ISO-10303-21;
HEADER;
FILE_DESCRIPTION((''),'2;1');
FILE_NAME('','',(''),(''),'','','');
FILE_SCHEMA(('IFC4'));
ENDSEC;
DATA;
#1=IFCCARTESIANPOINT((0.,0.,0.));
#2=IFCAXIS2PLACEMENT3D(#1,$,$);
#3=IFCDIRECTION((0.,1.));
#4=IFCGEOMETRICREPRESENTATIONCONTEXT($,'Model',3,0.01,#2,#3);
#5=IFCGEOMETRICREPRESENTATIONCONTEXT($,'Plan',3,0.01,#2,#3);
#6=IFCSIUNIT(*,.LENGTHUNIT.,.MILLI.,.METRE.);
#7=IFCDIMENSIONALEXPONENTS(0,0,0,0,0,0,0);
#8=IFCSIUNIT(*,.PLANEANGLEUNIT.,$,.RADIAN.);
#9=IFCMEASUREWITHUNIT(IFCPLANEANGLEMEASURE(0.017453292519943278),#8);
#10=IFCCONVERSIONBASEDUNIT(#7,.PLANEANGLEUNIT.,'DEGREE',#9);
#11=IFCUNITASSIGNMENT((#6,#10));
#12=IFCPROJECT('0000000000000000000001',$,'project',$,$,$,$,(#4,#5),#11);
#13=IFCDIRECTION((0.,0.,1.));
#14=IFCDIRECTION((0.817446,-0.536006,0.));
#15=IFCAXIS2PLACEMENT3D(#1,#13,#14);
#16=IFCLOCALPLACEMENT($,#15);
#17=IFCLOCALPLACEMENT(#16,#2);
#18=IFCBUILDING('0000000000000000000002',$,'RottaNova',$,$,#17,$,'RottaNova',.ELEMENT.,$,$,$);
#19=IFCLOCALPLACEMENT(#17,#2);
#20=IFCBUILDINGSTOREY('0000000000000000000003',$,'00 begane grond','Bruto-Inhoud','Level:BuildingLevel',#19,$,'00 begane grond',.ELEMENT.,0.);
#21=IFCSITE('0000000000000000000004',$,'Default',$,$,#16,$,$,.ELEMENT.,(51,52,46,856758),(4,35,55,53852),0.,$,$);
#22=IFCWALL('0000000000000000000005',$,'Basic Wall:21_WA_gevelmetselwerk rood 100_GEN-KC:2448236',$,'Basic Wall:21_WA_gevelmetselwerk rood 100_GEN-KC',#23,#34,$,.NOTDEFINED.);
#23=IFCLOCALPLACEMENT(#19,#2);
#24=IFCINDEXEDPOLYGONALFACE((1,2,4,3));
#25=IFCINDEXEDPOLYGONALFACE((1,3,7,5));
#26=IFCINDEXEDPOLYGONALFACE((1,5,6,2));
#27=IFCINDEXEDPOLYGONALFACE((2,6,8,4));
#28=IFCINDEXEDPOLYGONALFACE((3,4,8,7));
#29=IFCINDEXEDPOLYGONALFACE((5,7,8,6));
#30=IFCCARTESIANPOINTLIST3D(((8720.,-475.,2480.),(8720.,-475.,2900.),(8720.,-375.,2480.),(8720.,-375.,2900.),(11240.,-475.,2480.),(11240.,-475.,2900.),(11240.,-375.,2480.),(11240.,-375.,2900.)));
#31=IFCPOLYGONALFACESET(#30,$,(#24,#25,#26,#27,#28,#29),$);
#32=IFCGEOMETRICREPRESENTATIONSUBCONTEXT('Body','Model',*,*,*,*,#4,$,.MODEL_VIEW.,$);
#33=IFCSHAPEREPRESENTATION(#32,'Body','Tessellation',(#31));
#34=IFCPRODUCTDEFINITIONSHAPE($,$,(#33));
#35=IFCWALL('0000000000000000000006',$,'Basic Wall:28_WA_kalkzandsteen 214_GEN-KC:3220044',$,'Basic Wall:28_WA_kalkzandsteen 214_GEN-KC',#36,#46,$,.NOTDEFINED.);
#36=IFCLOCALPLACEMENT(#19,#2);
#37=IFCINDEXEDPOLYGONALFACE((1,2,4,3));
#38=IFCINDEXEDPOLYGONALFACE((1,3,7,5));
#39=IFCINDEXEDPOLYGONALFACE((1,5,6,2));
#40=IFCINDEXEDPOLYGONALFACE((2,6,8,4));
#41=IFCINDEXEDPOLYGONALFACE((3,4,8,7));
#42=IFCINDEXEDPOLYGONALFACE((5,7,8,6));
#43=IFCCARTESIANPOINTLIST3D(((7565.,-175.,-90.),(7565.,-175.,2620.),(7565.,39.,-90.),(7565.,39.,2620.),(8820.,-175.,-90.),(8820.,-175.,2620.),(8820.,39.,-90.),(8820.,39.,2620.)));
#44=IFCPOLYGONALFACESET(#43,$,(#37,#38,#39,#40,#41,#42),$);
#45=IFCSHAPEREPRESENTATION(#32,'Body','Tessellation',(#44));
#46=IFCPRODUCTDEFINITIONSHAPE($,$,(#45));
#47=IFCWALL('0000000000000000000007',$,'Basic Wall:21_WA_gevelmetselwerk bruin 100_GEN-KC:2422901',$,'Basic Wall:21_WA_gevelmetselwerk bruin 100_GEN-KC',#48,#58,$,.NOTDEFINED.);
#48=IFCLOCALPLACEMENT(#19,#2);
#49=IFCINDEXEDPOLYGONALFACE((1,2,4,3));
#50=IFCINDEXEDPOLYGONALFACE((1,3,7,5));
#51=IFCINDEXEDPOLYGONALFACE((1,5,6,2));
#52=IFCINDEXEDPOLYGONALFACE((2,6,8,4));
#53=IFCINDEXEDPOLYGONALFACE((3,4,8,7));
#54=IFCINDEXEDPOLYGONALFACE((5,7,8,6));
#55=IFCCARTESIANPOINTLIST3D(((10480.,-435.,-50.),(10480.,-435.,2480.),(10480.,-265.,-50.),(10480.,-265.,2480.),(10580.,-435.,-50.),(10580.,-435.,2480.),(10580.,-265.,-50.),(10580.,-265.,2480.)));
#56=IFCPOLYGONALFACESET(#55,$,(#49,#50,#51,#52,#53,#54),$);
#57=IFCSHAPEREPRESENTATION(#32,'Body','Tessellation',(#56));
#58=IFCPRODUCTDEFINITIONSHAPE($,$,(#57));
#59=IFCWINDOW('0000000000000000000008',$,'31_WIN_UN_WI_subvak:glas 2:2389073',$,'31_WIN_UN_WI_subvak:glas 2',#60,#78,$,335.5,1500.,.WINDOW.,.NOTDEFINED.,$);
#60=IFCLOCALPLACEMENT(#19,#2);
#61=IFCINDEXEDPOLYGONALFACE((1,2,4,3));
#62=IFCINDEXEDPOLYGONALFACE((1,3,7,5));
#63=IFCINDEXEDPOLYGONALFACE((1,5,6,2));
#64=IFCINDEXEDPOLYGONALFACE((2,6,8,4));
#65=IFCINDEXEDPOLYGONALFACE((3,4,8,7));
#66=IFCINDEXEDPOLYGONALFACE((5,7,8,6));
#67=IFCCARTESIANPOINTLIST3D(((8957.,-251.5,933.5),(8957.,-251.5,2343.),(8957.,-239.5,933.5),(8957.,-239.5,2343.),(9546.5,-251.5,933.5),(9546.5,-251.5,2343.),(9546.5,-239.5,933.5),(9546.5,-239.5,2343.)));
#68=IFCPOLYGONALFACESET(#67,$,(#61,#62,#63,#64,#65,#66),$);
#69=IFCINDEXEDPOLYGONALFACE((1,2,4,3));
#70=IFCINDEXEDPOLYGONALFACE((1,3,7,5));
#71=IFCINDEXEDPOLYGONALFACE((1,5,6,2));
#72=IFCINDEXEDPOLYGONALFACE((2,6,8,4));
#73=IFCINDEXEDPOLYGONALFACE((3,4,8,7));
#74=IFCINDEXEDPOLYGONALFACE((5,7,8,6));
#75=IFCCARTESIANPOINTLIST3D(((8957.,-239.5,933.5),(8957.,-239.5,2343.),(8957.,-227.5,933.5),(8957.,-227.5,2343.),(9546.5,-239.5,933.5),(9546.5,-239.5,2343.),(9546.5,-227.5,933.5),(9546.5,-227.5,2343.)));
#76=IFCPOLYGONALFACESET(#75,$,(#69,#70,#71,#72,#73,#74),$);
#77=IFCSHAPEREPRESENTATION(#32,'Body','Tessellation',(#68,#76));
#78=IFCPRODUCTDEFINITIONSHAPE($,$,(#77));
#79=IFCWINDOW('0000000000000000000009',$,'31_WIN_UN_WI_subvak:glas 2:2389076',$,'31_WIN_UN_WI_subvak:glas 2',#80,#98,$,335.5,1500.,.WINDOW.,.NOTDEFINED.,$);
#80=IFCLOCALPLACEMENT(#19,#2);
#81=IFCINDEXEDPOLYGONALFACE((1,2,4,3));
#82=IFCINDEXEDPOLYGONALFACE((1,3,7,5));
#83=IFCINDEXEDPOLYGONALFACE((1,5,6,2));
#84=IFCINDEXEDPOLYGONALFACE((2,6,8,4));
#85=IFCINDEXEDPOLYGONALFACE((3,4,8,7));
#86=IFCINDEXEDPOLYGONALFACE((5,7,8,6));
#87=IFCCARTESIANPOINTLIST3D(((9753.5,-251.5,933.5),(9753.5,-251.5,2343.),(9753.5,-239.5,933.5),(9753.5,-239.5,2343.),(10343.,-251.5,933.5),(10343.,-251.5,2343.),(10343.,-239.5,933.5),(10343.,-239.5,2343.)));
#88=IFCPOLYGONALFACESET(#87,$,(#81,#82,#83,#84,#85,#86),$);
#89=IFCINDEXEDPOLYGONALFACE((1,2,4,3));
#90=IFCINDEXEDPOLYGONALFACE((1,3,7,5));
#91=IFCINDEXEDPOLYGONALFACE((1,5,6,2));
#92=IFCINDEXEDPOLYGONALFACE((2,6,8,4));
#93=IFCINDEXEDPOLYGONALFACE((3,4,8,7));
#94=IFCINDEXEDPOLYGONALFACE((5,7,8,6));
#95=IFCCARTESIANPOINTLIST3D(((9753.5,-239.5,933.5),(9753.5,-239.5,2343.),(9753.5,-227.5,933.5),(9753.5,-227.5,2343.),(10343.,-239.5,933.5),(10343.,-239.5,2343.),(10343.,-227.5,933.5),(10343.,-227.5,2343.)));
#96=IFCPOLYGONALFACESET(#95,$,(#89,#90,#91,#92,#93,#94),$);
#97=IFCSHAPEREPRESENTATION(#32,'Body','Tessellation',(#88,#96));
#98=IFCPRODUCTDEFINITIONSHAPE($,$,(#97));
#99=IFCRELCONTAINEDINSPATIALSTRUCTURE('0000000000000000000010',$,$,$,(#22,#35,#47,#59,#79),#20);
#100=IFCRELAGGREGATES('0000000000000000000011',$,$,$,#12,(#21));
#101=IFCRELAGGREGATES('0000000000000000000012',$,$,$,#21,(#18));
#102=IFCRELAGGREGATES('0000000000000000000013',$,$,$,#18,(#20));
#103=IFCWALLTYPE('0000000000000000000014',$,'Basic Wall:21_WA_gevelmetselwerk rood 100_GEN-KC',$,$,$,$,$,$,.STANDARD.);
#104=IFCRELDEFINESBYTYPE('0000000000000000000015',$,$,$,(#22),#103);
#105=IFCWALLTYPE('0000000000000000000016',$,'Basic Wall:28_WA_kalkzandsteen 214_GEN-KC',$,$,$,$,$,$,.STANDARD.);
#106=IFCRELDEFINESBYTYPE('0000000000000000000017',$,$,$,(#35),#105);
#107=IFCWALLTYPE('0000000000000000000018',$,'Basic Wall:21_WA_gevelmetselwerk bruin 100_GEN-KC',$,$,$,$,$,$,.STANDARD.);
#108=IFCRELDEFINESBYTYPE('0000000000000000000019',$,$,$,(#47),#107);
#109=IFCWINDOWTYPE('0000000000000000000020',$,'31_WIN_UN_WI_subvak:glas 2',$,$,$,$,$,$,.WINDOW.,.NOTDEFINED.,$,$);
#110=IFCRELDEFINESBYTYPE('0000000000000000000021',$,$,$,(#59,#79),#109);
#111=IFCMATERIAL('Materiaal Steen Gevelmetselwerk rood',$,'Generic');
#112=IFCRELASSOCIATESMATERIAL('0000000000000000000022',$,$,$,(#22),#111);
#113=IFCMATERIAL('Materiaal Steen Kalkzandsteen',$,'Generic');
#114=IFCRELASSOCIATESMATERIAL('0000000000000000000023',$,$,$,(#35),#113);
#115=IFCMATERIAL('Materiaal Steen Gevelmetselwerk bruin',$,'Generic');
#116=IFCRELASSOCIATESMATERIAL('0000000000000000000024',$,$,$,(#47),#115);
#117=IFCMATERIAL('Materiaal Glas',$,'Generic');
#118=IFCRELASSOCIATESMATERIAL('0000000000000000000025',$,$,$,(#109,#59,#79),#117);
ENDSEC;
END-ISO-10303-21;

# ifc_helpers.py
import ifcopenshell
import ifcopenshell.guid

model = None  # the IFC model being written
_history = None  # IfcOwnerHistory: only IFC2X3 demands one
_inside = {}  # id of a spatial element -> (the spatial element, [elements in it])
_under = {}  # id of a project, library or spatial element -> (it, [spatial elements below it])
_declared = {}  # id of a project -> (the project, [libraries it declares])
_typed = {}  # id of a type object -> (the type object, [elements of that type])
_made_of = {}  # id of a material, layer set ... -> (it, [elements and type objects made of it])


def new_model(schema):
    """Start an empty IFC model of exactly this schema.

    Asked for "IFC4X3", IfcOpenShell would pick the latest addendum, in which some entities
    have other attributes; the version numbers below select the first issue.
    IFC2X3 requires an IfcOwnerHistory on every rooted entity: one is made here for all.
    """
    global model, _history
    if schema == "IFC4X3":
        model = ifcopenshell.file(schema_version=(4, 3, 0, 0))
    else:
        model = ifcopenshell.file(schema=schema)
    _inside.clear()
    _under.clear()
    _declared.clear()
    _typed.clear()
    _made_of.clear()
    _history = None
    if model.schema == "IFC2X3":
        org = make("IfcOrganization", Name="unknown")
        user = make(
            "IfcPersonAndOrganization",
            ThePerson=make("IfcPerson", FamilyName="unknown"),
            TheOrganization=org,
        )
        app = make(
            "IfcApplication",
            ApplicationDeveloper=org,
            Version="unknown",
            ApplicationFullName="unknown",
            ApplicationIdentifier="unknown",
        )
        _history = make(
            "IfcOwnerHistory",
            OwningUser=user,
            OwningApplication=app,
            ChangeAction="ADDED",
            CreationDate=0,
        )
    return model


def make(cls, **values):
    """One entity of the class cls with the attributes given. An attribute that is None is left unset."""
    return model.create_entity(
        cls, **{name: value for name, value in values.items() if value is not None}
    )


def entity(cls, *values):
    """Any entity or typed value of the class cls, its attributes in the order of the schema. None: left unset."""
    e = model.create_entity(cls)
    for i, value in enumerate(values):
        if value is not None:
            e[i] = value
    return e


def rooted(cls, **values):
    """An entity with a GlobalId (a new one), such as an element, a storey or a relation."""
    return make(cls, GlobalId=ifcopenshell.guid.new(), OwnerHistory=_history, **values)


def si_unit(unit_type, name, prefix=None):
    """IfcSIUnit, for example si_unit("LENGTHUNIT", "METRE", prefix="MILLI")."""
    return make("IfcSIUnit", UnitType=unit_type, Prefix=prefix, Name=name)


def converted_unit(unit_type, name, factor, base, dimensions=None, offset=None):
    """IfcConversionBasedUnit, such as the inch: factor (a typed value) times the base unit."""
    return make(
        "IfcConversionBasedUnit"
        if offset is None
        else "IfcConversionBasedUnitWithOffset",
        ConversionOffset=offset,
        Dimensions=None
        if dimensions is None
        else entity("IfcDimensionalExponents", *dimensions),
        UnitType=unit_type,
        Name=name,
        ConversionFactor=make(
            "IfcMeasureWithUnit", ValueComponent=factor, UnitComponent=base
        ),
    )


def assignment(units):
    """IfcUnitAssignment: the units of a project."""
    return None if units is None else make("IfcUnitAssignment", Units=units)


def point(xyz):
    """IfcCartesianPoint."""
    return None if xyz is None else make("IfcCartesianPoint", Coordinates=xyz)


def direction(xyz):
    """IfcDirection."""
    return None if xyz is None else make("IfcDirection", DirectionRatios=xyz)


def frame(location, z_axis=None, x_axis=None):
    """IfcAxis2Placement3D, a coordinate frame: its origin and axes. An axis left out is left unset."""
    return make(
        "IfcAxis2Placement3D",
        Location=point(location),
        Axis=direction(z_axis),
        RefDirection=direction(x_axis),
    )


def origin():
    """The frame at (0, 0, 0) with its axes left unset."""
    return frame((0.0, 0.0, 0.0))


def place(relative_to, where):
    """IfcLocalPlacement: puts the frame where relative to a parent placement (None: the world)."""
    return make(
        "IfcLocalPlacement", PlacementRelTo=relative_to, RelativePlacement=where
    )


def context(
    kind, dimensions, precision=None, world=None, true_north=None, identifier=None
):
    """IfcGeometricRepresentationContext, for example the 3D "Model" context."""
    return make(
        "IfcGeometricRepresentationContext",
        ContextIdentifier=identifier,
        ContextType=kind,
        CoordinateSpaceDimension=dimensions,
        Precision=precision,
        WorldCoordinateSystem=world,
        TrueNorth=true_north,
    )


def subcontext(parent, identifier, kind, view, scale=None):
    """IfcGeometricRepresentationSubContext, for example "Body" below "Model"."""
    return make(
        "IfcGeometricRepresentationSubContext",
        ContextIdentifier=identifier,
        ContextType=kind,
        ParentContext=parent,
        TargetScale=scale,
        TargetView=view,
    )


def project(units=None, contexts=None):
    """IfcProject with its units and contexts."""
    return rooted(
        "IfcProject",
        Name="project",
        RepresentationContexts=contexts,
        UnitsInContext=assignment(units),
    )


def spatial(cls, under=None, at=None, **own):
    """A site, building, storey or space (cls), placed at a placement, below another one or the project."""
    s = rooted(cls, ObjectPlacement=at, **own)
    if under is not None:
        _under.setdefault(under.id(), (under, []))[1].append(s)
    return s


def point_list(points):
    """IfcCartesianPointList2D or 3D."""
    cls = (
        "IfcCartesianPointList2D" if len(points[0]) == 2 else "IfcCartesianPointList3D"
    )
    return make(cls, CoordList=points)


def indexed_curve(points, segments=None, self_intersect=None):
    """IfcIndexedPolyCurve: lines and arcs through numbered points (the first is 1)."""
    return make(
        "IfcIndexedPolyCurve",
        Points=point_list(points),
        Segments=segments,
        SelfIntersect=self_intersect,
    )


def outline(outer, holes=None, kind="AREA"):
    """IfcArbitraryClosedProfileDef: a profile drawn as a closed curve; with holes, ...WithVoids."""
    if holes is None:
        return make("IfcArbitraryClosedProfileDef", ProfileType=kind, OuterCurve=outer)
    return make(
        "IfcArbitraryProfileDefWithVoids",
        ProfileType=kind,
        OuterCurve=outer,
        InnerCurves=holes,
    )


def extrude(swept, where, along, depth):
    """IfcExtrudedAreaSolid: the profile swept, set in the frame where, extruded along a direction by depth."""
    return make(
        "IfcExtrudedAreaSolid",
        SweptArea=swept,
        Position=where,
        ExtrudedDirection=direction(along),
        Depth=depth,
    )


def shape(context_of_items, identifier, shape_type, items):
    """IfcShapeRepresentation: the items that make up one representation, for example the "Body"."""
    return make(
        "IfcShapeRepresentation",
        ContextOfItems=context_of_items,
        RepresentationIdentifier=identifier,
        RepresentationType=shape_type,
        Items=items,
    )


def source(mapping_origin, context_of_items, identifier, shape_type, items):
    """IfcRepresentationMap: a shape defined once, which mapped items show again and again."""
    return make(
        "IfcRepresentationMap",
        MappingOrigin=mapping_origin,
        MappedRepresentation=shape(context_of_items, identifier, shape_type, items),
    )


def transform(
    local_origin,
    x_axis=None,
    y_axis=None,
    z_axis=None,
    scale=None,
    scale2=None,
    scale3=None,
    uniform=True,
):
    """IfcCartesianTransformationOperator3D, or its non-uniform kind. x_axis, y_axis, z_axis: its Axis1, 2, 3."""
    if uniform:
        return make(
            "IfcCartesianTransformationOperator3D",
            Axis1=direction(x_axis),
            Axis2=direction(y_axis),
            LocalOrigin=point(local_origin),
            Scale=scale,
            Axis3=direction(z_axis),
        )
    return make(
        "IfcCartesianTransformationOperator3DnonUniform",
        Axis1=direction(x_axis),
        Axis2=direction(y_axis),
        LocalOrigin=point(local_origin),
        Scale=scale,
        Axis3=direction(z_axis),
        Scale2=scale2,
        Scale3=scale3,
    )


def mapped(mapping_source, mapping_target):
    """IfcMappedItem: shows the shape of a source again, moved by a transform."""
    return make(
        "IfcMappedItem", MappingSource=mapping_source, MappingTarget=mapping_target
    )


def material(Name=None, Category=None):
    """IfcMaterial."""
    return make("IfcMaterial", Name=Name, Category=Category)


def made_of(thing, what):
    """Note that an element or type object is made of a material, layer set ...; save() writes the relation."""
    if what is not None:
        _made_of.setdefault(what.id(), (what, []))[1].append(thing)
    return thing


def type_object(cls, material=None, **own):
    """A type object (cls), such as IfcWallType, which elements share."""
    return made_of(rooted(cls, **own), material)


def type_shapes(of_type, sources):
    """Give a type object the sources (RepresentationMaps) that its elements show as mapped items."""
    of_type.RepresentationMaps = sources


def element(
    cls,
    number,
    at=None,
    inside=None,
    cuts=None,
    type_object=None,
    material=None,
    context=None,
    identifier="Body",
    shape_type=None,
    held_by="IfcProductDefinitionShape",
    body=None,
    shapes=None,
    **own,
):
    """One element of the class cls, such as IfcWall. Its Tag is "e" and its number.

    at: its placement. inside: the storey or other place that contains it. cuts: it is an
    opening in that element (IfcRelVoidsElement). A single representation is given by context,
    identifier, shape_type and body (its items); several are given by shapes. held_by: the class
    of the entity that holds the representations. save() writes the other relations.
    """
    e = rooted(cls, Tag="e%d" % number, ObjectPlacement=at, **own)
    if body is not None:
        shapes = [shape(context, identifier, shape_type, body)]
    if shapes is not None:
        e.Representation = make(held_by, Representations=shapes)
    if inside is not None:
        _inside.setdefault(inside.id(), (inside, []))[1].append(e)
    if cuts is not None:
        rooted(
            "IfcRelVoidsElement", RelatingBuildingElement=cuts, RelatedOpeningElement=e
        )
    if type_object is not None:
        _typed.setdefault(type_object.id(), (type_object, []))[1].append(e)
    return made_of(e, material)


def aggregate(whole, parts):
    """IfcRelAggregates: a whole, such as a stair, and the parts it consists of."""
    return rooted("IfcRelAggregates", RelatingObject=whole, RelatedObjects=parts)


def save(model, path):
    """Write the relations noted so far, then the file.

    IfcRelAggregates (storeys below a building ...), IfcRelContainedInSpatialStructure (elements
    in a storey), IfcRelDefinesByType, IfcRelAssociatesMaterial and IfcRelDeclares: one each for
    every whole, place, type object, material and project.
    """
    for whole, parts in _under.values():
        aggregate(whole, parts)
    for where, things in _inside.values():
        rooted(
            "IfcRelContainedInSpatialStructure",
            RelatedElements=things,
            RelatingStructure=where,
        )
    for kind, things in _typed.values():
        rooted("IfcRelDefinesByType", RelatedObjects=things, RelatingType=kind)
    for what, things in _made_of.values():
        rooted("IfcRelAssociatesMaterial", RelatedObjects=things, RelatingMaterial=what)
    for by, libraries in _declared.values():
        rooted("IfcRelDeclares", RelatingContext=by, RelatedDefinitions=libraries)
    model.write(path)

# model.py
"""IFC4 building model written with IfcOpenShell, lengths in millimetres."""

from ifc_helpers import new_model, entity, si_unit, converted_unit, direction, frame, origin, place, context, subcontext, project, spatial, indexed_curve, outline, extrude, source, transform, mapped, material, type_object, type_shapes, element, save


model = new_model("IFC4")

# Units and contexts
model_context = context("Model", 3, precision=0.01, world=origin(), true_north=direction((0.0, 1.0)))
plan_context = context("Plan", 3, precision=0.01, world=origin(), true_north=direction((0.0, 1.0)))
body_context = subcontext(model_context, "Body", "Model", "MODEL_VIEW")
ifc_project = project(units=[si_unit("LENGTHUNIT", "METRE", prefix="MILLI"), converted_unit("PLANEANGLEUNIT", "DEGREE", entity("IfcPlaneAngleMeasure", 0.017453292519943278), si_unit("PLANEANGLEUNIT", "RADIAN"), dimensions=[0, 0, 0, 0, 0, 0, 0])], contexts=[model_context, plan_context])

# Site, building, storey
site_placement = place(None, frame((0.0, 0.0, 0.0), z_axis=(0.0, 0.0, 1.0), x_axis=(0.817446, -0.536006, 0.0)))
site = spatial("IfcSite", under=ifc_project, at=site_placement, Name="Default", CompositionType="ELEMENT", RefLatitude=(51, 52, 46, 856758), RefLongitude=(4, 35, 55, 53852), RefElevation=0.0)
building_placement = place(site_placement, origin())
building = spatial("IfcBuilding", under=site, at=building_placement, Name="RottaNova", LongName="RottaNova", CompositionType="ELEMENT")
storey_placement = place(building_placement, origin())
storey = spatial("IfcBuildingStorey", under=building, at=storey_placement, Name="00 begane grond", Description="Bruto-Inhoud", ObjectType="Level:BuildingLevel", LongName="00 begane grond", CompositionType="ELEMENT", Elevation=0.0)

# Shared definitions
ifc_material_1 = material(Name="Materiaal Glas", Category="Generic")

# Walls
ifc_material_2 = material(Name="Materiaal Steen Gevelmetselwerk rood", Category="Generic")
wall_type_1 = type_object("IfcWallType", Name="Basic Wall:21_WA_gevelmetselwerk rood 100_GEN-KC", PredefinedType="STANDARD")
wall_1_placement = place(storey_placement, frame((8720.0, -425.0, 2480.0)))
element("IfcWall", 1, at=wall_1_placement, inside=storey, type_object=wall_type_1, material=ifc_material_2, Name="Basic Wall:21_WA_gevelmetselwerk rood 100_GEN-KC:2448236", ObjectType="Basic Wall:21_WA_gevelmetselwerk rood 100_GEN-KC", PredefinedType="NOTDEFINED", context=body_context, shape_type="SweptSolid", body=[
    extrude(outline(indexed_curve([(2520.0, 50.0), (0.0, 50.0), (0.0, -50.0), (2520.0, -50.0), (2520.0, 50.0)], self_intersect=False)), origin(), (0.0, 0.0, 1.0), 420.0),
])
ifc_material_3 = material(Name="Materiaal Steen Kalkzandsteen", Category="Generic")
wall_type_2 = type_object("IfcWallType", Name="Basic Wall:28_WA_kalkzandsteen 214_GEN-KC", PredefinedType="STANDARD")
wall_2_placement = place(storey_placement, frame((8820.0, -68.0, -90.0), z_axis=(0.0, 0.0, 1.0), x_axis=(-1.0, 0.0, 0.0)))
element("IfcWall", 2, at=wall_2_placement, inside=storey, type_object=wall_type_2, material=ifc_material_3, Name="Basic Wall:28_WA_kalkzandsteen 214_GEN-KC:3220044", ObjectType="Basic Wall:28_WA_kalkzandsteen 214_GEN-KC", PredefinedType="NOTDEFINED", context=body_context, shape_type="SweptSolid", body=[
    extrude(outline(indexed_curve([(1255.0, 107.0), (0.0, 107.0), (0.0, -107.0), (1255.0, -107.0), (1255.0, 107.0)], self_intersect=False)), origin(), (0.0, 0.0, 1.0), 2710.0),
])
ifc_material_4 = material(Name="Materiaal Steen Gevelmetselwerk bruin", Category="Generic")
wall_type_3 = type_object("IfcWallType", Name="Basic Wall:21_WA_gevelmetselwerk bruin 100_GEN-KC", PredefinedType="STANDARD")
wall_3_placement = place(storey_placement, frame((10530.0, -265.0, -50.0), z_axis=(0.0, 0.0, 1.0), x_axis=(0.0, -1.0, 0.0)))
element("IfcWall", 3, at=wall_3_placement, inside=storey, type_object=wall_type_3, material=ifc_material_4, Name="Basic Wall:21_WA_gevelmetselwerk bruin 100_GEN-KC:2422901", ObjectType="Basic Wall:21_WA_gevelmetselwerk bruin 100_GEN-KC", PredefinedType="NOTDEFINED", context=body_context, shape_type="SweptSolid", body=[
    extrude(outline(indexed_curve([(170.0, 50.0), (0.0, 50.0), (0.0, -50.0), (170.0, -50.0), (170.0, 50.0)], self_intersect=False)), origin(), (0.0, 0.0, 1.0), 2530.0),
])

# Windows
window_type = type_object("IfcWindowType", Name="31_WIN_UN_WI_subvak:glas 2", PartitioningType="NOTDEFINED", PredefinedType="WINDOW", material=ifc_material_1)
shared_shape_1 = source(origin(), body_context, "Body", "SweptSolid", [
    extrude(outline(indexed_curve([(-294.7, -6.0), (294.7, -6.0), (294.7, 6.0), (-294.7, 6.0), (-294.7, -6.0)], self_intersect=False)), frame((0.0, -6.0, 0.0)), (0.0, 0.0, 1.0), 1409.5),
    extrude(outline(indexed_curve([(-294.8, -6.0), (294.8, -6.0), (294.8, 6.0), (-294.8, 6.0), (-294.8, -6.0)], self_intersect=False)), frame((0.0, 6.0, 0.0)), (0.0, 0.0, 1.0), 1409.5),
])
type_shapes(window_type, [shared_shape_1])
for number, where, name in (
    (4, (9251.7, -239.5, 933.5), "31_WIN_UN_WI_subvak:glas 2:2389073"),
    (5, (10048.2, -239.5, 933.5), "31_WIN_UN_WI_subvak:glas 2:2389076"),
):
    element("IfcWindow", number, at=place(storey_placement, frame(where)), inside=storey, type_object=window_type, material=ifc_material_1, Name=name, ObjectType="31_WIN_UN_WI_subvak:glas 2", OverallHeight=335.5, OverallWidth=1500.0, PartitioningType="NOTDEFINED", PredefinedType="WINDOW", context=body_context, shape_type="MappedRepresentation", body=[
        mapped(shared_shape_1, transform((0.0, 0.0, 0.0), scale=1.0)),
    ])

save(model, "model.ifc")
